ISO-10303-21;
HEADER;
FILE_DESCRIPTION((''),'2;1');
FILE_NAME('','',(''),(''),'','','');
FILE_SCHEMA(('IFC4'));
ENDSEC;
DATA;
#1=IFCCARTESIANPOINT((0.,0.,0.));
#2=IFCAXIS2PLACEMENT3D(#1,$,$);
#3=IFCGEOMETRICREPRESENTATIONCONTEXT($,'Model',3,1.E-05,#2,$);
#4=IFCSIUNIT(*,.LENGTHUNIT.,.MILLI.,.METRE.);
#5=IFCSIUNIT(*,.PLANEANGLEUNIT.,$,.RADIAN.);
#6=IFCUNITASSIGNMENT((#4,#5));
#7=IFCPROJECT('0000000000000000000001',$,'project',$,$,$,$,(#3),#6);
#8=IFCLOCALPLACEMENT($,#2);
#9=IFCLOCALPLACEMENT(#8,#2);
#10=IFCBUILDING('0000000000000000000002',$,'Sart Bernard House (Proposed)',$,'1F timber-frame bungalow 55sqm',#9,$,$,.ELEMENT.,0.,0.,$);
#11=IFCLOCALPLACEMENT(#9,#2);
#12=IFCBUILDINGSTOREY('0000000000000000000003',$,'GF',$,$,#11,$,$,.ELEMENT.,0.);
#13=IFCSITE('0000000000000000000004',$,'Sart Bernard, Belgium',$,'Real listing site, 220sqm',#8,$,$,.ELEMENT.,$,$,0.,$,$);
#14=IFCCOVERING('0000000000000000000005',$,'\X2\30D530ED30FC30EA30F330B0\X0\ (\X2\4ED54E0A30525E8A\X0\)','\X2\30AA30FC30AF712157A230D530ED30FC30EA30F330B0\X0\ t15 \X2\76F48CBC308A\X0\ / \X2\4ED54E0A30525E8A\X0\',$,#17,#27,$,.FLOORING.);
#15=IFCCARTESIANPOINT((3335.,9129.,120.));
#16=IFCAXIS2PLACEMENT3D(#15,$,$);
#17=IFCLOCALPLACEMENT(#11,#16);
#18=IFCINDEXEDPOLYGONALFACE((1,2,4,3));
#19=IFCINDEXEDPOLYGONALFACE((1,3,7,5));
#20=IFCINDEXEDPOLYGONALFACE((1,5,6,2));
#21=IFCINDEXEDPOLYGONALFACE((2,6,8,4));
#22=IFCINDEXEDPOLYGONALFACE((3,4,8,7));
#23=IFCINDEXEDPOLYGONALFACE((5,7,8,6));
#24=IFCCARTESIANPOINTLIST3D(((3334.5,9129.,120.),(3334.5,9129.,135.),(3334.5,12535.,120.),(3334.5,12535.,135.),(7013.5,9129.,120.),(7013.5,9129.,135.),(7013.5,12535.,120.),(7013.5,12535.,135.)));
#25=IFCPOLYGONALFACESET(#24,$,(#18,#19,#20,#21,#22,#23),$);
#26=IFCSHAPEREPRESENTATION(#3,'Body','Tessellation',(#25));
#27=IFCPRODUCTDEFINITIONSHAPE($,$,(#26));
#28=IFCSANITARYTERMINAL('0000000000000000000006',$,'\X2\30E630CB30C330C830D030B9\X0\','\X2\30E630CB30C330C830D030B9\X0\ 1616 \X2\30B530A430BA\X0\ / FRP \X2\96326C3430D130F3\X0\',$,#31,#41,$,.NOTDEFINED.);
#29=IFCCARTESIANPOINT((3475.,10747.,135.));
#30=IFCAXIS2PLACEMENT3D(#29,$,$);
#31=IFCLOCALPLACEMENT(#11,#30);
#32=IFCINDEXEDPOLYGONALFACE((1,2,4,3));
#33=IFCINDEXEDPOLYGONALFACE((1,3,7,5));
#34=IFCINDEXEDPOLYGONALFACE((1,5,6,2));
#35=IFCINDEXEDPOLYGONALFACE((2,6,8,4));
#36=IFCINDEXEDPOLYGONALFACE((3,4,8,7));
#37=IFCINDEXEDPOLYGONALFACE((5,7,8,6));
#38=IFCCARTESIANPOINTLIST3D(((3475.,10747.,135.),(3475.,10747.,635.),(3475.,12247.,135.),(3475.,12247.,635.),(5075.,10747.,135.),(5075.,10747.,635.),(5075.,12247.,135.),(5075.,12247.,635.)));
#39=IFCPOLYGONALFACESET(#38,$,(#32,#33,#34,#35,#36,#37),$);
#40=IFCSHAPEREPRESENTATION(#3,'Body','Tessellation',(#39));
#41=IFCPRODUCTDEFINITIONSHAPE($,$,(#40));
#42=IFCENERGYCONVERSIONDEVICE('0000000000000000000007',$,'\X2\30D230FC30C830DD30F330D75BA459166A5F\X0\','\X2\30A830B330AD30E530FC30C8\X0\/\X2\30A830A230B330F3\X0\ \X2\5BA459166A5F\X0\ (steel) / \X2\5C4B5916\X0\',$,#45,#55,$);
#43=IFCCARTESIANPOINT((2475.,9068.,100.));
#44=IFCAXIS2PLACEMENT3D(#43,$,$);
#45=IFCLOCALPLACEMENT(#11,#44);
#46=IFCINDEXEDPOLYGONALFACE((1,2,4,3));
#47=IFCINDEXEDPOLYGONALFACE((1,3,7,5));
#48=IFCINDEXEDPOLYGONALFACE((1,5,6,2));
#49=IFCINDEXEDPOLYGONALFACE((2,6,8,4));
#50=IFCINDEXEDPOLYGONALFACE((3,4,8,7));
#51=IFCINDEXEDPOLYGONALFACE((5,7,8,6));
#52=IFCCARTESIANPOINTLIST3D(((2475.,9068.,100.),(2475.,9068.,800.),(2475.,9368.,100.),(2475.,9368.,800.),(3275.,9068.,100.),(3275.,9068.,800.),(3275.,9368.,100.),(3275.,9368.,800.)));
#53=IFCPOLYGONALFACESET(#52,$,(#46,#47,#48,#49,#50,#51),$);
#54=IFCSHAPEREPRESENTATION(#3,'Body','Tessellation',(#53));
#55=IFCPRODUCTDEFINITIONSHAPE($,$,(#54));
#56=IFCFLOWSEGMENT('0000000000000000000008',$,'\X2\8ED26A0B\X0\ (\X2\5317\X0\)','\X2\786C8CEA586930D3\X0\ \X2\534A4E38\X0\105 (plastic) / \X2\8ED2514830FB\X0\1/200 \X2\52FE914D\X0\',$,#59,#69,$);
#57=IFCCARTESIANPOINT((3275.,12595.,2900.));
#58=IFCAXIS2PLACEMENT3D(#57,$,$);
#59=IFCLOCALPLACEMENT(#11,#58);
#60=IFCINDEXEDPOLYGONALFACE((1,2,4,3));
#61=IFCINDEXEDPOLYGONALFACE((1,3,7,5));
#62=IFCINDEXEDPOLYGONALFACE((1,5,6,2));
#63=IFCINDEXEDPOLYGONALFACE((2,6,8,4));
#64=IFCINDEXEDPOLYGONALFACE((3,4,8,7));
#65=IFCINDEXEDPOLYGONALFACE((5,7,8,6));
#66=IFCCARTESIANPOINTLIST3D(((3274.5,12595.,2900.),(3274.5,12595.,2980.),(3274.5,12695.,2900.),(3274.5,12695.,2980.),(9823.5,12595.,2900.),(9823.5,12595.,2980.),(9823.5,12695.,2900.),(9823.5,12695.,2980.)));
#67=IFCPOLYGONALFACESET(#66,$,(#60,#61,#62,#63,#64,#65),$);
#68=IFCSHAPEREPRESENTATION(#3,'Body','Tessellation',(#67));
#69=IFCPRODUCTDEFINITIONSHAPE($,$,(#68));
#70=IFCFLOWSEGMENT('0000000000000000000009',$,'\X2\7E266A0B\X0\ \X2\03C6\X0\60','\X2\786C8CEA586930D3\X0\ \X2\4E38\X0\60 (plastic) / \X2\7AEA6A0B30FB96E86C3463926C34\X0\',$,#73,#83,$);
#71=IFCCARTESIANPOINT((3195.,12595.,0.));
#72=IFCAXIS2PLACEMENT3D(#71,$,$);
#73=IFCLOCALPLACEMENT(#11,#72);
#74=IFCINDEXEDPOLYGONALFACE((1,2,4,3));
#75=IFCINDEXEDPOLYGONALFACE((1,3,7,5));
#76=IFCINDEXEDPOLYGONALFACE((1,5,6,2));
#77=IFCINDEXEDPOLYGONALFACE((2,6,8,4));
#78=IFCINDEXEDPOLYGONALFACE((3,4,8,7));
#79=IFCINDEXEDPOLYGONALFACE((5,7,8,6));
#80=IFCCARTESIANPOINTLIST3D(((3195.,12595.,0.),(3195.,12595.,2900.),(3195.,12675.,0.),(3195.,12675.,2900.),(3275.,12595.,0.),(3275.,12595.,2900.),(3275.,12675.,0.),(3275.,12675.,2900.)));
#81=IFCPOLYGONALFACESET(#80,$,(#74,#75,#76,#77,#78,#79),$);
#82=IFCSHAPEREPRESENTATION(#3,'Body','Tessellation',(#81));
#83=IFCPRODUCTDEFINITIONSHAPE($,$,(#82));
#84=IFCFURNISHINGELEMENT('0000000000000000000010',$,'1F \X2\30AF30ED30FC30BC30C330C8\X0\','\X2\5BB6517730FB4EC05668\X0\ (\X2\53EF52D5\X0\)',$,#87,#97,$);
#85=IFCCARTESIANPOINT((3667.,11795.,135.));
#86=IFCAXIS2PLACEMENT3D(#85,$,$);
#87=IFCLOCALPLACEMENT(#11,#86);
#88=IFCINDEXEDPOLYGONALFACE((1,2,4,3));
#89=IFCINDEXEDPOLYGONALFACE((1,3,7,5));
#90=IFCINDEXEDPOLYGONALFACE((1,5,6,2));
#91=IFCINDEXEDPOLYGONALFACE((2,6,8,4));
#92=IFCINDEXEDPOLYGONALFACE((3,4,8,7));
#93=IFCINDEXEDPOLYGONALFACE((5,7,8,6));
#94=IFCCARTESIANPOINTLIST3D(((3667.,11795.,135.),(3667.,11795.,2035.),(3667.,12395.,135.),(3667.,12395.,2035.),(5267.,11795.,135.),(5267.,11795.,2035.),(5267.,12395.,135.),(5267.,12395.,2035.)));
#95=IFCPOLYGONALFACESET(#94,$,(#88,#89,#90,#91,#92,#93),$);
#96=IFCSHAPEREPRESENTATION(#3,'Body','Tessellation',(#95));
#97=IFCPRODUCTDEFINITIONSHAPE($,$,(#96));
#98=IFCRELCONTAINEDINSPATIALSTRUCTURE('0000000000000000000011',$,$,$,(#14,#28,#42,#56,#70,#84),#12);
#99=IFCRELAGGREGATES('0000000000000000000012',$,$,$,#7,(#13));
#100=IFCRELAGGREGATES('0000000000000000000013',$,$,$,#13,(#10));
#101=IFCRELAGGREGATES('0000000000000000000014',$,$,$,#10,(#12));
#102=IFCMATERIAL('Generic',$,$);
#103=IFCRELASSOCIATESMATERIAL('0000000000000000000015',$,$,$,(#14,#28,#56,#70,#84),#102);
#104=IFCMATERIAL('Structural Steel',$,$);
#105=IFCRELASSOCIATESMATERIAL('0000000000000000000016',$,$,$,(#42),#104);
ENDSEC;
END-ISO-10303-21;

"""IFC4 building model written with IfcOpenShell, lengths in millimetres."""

from ifc_helpers import new_model, si_unit, frame, frame_2d, origin, place, context, project, spatial, rectangle, extrude, material, element, save


model = new_model("IFC4")

# Units and contexts
model_context = context("Model", 3, precision=1e-05, world=origin())
ifc_project = project(units=[si_unit("LENGTHUNIT", "METRE", prefix="MILLI"), si_unit("PLANEANGLEUNIT", "RADIAN")], contexts=[model_context])

# Site, building, storey
site_placement = place(None, origin())
site = spatial("IfcSite", under=ifc_project, at=site_placement, Name="Sart Bernard, Belgium", ObjectType="Real listing site, 220sqm", CompositionType="ELEMENT", RefElevation=0.0)
building_placement = place(site_placement, origin())
building = spatial("IfcBuilding", under=site, at=building_placement, Name="Sart Bernard House (Proposed)", ObjectType="1F timber-frame bungalow 55sqm", CompositionType="ELEMENT", ElevationOfRefHeight=0.0, ElevationOfTerrain=0.0)
storey_placement = place(building_placement, origin())
storey = spatial("IfcBuildingStorey", under=building, at=storey_placement, Name="GF", CompositionType="ELEMENT", Elevation=0.0)

# Shared definitions
ifc_material_1 = material(Name="Structural Steel")

# Covering
ifc_material_2 = material(Name="Generic")
covering_placement = place(storey_placement, frame((3335.0, 9129.0, 120.0)))
element("IfcCovering", 1, at=covering_placement, inside=storey, material=ifc_material_2, Name="フローリング (仕上げ床)", Description="オーク無垢フローリング t15 直貼り / 仕上げ床", PredefinedType="FLOORING", context=model_context, shape_type="SweptSolid", body=[
    extrude(rectangle(XDim=3679.0, YDim=3406.0, at=frame_2d((1839.0, 1703.0))), frame((3335.0, 9129.0, 120.0)), (0.0, 0.0, 1.0), 15.0),
])

# Sanitary terminal
sanitary_terminal_placement = place(storey_placement, frame((3475.0, 10747.0, 135.0)))
element("IfcSanitaryTerminal", 2, at=sanitary_terminal_placement, inside=storey, material=ifc_material_2, Name="ユニットバス", Description="ユニットバス 1616 サイズ / FRP 防水パン", PredefinedType="NOTDEFINED", context=model_context, shape_type="SweptSolid", body=[
    extrude(rectangle(XDim=1600.0, YDim=1500.0, at=frame_2d((800.0, 750.0))), frame((3475.0, 10747.0, 135.0)), (0.0, 0.0, 1.0), 500.0),
])

# Energy conversion device
energy_conversion_device_placement = place(storey_placement, frame((2475.0, 9068.0, 100.0)))
element("IfcEnergyConversionDevice", 3, at=energy_conversion_device_placement, inside=storey, material=ifc_material_1, Name="ヒートポンプ室外機", Description="エコキュート/エアコン 室外機 (steel) / 屋外", context=model_context, shape_type="SweptSolid", body=[
    extrude(rectangle(XDim=800.0, YDim=300.0, at=frame_2d((400.0, 150.0))), frame((2475.0, 9068.0, 100.0)), (0.0, 0.0, 1.0), 700.0),
])

# Flow segments
flow_segment_1_placement = place(storey_placement, frame((3275.0, 12595.0, 2900.0)))
element("IfcFlowSegment", 4, at=flow_segment_1_placement, inside=storey, material=ifc_material_2, Name="軒樋 (北)", Description="硬質塩ビ 半丸105 (plastic) / 軒先・1/200 勾配", context=model_context, shape_type="SweptSolid", body=[
    extrude(rectangle(XDim=6549.0, YDim=100.0, at=frame_2d((3274.0, 50.0))), frame((3275.0, 12595.0, 2900.0)), (0.0, 0.0, 1.0), 80.0),
])
flow_segment_2_placement = place(storey_placement, frame((3195.0, 12595.0, 0.0)))
element("IfcFlowSegment", 5, at=flow_segment_2_placement, inside=storey, material=ifc_material_2, Name="縦樋 φ60", Description="硬質塩ビ 丸60 (plastic) / 竪樋・雨水排水", context=model_context, shape_type="SweptSolid", body=[
    extrude(rectangle(XDim=80.0, YDim=80.0, at=frame_2d((40.0, 40.0))), frame((3195.0, 12595.0, 0.0)), (0.0, 0.0, 1.0), 2900.0),
])

# Furnishing element
furnishing_placement = place(storey_placement, frame((3667.0, 11795.0, 135.0)))
element("IfcFurnishingElement", 6, at=furnishing_placement, inside=storey, material=ifc_material_2, Name="1F クローゼット", Description="家具・什器 (可動)", context=model_context, shape_type="SweptSolid", body=[
    extrude(rectangle(XDim=1600.0, YDim=600.0, at=frame_2d((800.0, 300.0))), frame((3667.0, 11795.0, 135.0)), (0.0, 0.0, 1.0), 1900.0),
])

save(model, "model.ifc")
